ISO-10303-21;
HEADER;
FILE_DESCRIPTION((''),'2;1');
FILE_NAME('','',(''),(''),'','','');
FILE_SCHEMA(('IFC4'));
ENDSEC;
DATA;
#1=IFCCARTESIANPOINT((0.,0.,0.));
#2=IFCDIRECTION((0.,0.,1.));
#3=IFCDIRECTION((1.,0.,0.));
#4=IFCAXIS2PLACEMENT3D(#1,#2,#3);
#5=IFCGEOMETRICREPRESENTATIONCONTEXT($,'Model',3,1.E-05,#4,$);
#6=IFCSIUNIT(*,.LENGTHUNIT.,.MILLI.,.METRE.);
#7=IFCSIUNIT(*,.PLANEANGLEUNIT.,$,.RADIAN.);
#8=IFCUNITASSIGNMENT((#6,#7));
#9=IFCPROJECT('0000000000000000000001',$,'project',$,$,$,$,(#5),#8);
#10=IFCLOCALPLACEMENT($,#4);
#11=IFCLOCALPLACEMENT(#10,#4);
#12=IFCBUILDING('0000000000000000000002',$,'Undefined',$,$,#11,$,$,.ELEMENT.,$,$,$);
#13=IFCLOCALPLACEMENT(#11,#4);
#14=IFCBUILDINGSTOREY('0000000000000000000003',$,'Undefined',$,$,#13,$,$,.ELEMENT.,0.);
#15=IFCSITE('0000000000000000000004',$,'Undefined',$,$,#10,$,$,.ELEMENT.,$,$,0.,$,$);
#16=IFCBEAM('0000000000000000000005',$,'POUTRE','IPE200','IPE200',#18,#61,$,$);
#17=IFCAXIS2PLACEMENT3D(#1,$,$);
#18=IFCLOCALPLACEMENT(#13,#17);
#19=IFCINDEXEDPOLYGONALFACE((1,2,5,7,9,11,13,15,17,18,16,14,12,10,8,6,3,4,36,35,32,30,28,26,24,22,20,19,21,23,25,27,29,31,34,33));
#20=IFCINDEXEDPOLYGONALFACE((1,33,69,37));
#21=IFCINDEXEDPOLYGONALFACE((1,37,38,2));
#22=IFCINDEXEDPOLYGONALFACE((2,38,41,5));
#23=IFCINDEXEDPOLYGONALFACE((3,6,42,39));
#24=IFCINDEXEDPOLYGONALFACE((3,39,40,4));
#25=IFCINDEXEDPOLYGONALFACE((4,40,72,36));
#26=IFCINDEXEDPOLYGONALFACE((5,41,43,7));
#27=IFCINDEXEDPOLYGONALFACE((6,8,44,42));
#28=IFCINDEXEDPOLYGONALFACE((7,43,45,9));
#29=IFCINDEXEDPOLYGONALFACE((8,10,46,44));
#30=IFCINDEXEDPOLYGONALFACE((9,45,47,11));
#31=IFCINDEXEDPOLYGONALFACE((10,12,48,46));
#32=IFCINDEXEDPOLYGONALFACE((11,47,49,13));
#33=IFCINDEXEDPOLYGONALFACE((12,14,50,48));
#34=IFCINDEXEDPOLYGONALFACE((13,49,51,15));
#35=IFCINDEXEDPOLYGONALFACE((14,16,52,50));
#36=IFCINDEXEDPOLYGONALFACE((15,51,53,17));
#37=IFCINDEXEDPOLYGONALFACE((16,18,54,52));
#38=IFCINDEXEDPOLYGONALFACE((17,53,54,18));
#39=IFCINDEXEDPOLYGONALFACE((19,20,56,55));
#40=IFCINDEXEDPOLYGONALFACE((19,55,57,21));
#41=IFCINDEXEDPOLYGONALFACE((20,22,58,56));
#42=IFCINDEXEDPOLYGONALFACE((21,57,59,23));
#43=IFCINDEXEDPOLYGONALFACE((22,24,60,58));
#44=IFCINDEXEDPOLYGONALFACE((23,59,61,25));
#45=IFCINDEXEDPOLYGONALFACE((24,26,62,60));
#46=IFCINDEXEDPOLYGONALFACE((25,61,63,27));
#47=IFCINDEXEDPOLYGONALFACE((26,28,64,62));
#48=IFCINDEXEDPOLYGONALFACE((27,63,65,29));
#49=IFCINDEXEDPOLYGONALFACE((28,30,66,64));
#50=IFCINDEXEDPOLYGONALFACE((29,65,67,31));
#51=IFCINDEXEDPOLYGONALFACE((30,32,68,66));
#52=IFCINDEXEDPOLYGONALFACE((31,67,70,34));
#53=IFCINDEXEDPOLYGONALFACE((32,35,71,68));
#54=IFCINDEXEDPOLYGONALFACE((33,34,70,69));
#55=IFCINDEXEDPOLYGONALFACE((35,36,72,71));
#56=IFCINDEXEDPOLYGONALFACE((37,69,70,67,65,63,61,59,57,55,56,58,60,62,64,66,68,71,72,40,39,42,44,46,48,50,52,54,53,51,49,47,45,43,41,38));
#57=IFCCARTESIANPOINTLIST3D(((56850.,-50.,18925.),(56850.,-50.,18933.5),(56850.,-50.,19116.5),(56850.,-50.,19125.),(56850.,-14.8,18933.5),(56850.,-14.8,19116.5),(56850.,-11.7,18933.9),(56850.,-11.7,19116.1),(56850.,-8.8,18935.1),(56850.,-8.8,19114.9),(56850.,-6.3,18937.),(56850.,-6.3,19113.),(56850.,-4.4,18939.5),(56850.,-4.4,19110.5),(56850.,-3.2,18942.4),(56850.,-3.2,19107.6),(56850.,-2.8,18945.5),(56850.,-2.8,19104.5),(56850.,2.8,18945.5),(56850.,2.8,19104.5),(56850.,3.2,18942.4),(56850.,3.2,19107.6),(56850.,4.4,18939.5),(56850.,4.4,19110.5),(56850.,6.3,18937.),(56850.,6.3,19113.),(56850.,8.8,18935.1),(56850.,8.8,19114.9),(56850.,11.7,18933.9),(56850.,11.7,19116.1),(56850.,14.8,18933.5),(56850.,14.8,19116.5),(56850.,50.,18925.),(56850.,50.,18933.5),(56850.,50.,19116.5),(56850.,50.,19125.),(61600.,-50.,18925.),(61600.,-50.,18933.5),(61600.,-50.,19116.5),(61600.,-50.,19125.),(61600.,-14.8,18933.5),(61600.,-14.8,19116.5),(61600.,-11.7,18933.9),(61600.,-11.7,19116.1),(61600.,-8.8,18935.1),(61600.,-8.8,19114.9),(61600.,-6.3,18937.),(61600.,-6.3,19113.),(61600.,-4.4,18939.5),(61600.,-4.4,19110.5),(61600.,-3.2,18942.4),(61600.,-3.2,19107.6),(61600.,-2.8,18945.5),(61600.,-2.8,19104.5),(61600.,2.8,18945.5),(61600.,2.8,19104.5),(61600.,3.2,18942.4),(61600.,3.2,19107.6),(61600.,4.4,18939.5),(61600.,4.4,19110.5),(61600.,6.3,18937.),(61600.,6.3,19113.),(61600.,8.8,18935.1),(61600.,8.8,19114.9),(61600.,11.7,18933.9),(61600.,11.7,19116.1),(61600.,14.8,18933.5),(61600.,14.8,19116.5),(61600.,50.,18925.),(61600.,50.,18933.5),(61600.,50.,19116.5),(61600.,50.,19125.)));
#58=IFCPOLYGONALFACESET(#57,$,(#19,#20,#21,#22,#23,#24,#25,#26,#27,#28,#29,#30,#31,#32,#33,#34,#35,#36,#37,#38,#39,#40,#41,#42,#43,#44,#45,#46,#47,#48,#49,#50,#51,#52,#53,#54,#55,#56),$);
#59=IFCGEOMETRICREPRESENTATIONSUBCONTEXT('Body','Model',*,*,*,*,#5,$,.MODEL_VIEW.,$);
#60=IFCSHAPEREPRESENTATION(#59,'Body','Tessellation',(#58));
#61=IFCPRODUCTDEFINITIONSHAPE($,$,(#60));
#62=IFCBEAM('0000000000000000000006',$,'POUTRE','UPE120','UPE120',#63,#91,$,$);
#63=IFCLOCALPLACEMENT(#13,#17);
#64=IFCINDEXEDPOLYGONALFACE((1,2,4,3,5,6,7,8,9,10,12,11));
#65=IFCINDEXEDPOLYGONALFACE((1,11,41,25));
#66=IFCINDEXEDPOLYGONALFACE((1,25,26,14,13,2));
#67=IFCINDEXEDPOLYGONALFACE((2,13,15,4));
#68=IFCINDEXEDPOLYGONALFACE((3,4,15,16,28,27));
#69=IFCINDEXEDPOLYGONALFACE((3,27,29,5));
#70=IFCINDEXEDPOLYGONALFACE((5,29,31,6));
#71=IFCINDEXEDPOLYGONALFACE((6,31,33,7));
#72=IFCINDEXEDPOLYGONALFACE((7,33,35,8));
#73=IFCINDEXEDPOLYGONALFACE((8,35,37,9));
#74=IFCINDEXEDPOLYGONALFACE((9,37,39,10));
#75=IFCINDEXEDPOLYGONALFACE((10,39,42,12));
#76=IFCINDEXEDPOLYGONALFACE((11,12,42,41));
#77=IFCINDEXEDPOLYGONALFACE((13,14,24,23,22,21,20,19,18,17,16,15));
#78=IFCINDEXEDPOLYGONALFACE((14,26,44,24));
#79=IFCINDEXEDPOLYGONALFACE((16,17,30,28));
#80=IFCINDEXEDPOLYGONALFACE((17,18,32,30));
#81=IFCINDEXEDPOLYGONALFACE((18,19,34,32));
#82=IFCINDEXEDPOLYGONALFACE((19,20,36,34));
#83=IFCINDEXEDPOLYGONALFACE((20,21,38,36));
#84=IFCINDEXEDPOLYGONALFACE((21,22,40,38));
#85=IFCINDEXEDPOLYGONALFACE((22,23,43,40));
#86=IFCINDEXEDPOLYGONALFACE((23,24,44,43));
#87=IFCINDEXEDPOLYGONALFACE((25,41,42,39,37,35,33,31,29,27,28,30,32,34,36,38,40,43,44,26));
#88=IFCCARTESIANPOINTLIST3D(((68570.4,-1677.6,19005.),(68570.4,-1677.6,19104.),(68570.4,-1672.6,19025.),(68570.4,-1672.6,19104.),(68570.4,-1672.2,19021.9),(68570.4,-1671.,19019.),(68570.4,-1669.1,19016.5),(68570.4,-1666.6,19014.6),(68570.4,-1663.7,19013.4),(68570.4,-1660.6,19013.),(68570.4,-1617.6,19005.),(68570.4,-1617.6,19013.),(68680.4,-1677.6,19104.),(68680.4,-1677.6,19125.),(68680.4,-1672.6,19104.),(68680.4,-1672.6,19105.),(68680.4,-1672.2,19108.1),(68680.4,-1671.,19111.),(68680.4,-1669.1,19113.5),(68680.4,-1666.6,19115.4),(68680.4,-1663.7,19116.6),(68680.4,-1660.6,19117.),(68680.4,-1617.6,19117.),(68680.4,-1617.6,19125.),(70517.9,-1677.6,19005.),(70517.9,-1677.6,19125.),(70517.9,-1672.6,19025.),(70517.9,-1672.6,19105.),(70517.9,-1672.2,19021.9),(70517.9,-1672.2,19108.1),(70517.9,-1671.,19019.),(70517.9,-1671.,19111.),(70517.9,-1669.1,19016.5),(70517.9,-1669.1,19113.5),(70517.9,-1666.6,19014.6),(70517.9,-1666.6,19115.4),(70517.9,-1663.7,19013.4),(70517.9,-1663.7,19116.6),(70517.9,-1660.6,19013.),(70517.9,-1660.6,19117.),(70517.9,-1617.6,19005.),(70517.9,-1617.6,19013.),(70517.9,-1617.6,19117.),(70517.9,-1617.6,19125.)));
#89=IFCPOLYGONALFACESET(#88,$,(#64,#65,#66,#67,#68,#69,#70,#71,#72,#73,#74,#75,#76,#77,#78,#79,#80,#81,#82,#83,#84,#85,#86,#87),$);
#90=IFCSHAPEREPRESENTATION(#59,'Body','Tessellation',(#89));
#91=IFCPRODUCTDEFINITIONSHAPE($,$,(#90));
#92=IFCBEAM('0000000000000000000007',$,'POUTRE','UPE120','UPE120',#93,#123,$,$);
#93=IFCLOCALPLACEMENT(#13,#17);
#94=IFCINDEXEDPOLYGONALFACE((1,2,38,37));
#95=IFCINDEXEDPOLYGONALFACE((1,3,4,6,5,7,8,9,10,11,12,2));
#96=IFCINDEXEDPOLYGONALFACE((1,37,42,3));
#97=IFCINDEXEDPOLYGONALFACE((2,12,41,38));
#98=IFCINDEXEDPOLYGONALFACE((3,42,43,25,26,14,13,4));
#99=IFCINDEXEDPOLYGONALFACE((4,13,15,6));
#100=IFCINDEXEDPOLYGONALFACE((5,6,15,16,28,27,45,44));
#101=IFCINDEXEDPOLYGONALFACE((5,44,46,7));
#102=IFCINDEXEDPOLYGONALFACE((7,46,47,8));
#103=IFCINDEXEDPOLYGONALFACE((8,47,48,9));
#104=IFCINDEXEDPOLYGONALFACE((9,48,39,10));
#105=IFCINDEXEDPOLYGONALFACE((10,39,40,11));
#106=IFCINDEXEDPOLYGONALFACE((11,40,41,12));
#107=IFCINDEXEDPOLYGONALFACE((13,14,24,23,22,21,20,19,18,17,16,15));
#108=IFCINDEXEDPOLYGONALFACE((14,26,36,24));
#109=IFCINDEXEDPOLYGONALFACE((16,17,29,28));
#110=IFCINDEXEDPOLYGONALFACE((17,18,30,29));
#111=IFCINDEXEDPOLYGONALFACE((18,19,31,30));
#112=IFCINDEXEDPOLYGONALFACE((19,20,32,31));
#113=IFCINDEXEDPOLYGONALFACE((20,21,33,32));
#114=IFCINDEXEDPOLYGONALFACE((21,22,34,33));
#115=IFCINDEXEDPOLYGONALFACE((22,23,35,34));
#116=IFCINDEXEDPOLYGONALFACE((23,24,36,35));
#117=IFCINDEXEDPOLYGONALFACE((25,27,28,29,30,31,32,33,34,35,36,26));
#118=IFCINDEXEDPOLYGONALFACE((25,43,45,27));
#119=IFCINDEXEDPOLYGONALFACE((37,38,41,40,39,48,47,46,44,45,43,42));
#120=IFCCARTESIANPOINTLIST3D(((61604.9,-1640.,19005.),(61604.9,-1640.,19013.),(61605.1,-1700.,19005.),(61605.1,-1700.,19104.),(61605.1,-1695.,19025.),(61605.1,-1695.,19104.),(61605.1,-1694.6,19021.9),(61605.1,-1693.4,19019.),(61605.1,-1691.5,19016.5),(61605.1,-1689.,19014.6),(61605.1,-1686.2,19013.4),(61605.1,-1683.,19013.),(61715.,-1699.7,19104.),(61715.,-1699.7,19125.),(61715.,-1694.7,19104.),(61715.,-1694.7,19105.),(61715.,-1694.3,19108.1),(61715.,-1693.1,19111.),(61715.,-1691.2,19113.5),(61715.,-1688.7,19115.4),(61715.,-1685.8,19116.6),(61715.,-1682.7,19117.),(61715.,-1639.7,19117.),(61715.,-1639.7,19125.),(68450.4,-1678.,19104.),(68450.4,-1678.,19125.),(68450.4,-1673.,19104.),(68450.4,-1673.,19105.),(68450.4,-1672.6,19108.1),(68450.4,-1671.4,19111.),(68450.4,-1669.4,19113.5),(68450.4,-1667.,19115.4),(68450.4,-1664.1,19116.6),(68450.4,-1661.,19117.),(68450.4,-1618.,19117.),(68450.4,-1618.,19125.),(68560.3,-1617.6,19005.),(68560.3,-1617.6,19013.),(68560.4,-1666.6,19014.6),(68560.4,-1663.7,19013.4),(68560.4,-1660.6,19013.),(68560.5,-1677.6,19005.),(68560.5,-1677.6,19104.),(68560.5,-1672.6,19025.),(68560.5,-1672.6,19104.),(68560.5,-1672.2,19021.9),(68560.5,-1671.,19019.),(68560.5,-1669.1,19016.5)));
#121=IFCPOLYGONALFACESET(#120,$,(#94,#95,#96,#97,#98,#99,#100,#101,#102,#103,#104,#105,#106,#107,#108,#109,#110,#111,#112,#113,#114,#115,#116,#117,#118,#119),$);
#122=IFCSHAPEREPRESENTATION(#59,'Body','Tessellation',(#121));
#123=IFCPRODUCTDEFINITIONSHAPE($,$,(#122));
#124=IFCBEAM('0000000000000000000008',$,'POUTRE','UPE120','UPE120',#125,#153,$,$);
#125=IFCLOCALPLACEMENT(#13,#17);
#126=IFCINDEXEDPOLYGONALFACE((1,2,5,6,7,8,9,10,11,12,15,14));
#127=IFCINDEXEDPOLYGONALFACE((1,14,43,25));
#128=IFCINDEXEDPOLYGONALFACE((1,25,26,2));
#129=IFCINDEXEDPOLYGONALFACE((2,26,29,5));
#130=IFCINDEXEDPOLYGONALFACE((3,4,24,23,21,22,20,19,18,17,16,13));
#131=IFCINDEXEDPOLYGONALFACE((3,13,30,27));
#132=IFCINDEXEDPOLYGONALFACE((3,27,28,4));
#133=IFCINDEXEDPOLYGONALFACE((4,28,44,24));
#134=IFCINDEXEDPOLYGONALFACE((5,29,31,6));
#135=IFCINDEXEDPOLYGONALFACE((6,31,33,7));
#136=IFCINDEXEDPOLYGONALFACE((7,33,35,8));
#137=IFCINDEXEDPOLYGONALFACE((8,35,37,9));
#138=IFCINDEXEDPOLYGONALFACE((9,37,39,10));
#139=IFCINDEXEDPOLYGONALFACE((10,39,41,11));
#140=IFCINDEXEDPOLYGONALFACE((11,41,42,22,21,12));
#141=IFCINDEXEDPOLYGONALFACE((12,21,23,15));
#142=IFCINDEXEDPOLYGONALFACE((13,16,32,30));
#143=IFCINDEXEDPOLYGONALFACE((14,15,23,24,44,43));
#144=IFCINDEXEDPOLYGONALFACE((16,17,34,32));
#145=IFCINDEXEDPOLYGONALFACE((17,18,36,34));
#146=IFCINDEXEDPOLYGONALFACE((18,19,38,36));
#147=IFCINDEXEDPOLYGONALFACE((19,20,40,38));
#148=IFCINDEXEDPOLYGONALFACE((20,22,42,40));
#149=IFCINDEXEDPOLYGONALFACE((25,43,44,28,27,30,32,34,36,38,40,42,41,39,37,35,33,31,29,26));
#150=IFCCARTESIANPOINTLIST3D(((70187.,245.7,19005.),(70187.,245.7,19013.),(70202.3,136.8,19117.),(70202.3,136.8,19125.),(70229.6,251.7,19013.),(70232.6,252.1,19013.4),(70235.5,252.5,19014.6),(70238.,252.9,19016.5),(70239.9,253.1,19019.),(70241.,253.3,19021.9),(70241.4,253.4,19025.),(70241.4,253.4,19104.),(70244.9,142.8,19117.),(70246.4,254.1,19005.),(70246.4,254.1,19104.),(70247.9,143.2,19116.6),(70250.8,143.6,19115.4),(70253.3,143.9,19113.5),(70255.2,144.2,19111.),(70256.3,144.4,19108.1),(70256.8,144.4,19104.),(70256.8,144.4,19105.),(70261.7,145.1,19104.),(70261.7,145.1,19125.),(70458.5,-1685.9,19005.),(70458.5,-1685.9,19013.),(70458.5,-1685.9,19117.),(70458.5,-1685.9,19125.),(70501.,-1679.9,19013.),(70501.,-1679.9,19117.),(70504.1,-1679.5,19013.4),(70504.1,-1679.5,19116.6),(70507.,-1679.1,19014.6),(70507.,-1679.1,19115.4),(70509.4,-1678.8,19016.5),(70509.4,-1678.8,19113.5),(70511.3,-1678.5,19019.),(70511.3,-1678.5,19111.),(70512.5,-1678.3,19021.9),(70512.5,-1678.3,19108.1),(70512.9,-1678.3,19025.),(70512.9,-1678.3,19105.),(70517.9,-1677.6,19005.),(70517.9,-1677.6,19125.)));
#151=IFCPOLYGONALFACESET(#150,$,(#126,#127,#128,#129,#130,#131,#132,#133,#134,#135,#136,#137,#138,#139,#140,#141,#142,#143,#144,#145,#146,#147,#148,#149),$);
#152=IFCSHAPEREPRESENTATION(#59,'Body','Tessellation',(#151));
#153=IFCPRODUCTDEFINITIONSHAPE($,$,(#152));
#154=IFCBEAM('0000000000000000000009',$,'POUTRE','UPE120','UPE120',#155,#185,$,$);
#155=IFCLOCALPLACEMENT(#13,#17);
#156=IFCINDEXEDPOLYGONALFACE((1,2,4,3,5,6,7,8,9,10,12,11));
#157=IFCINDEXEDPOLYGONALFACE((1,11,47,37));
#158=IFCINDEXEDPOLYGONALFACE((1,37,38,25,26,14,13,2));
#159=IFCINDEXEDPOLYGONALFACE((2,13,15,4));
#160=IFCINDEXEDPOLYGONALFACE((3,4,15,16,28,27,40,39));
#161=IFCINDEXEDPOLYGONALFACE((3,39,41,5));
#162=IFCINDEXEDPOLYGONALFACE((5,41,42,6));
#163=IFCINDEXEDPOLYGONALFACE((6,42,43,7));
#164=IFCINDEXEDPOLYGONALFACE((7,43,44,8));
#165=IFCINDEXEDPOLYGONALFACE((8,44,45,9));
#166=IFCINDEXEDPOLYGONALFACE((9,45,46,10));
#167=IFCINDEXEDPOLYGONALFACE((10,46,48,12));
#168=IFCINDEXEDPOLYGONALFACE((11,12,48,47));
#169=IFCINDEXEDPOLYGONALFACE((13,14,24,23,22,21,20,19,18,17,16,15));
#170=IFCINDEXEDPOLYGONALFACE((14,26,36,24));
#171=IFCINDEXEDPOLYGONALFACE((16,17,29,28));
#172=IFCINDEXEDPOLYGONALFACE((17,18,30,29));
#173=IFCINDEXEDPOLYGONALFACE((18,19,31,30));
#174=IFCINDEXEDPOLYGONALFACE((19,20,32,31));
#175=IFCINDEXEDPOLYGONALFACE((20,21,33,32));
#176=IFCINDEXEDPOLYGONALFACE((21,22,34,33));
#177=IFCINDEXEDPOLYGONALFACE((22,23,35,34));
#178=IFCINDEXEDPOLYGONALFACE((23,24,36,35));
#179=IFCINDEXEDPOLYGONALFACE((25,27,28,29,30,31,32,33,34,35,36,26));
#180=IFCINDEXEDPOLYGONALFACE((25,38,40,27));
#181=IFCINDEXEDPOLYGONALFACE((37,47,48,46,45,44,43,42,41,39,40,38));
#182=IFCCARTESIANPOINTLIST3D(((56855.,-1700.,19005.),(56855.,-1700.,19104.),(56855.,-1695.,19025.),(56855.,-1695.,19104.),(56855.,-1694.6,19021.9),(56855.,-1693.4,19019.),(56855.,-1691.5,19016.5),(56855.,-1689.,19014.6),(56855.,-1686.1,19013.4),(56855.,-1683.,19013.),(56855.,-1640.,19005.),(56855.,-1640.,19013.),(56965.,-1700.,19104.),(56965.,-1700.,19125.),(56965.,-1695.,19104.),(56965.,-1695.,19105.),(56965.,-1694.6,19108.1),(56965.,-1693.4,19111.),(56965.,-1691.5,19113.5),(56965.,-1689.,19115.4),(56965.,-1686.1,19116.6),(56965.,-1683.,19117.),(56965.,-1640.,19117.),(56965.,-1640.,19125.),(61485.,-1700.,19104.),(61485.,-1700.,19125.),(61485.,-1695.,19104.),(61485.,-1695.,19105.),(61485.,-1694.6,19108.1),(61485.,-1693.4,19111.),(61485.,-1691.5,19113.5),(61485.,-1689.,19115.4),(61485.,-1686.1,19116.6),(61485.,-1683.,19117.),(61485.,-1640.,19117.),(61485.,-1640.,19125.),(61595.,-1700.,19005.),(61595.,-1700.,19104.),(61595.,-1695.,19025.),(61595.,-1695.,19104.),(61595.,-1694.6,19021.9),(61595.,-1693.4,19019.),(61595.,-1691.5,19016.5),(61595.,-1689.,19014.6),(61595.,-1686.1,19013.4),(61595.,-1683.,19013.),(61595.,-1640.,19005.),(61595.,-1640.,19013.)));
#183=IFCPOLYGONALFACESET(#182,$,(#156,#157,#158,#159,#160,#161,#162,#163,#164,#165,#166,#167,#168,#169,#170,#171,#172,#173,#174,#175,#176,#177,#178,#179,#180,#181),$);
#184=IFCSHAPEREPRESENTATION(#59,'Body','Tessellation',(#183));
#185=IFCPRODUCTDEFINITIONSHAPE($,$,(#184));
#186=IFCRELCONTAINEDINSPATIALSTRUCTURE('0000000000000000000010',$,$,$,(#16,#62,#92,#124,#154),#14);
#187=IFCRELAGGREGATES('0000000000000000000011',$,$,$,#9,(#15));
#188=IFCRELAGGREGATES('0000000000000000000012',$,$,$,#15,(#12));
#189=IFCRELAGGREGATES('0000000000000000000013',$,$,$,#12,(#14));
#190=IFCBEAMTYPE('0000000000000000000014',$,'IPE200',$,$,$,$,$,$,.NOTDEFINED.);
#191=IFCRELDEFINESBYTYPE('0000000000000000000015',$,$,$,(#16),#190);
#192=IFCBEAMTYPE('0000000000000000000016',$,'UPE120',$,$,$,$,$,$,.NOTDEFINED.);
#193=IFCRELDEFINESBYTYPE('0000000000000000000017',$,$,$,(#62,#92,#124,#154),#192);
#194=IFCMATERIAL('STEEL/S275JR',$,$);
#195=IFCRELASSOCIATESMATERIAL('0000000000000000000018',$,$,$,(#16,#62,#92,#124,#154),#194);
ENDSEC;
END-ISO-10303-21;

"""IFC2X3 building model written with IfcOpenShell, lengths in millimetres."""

from ifc_helpers import new_model, si_unit, frame, origin_with_axes, origin_2d_with_axis, place, context, subcontext, project, spatial, rectangle, i_section, u_section, extrude, boolean, material, type_object, element, save


model = new_model("IFC2X3")

# Units and contexts
model_context = context("Model", 3, precision=1e-05, world=origin_with_axes())
body_context = subcontext(model_context, "Body", "Model", "MODEL_VIEW")
ifc_project = project(units=[si_unit("LENGTHUNIT", "METRE", prefix="MILLI"), si_unit("PLANEANGLEUNIT", "RADIAN")], contexts=[model_context])

# Site, building, storey
site_placement = place(None, origin_with_axes())
site = spatial("IfcSite", under=ifc_project, at=site_placement, Name="Undefined", CompositionType="ELEMENT", RefElevation=0.0)
building_placement = place(site_placement, origin_with_axes())
building = spatial("IfcBuilding", under=site, at=building_placement, Name="Undefined", CompositionType="ELEMENT")
storey_placement = place(building_placement, origin_with_axes())
storey = spatial("IfcBuildingStorey", under=building, at=storey_placement, Name="Undefined", CompositionType="ELEMENT", Elevation=0.0)

# Shared definitions
ifc_material_1 = material(Name="STEEL/S275JR")

# Beams
beam_type_1 = type_object("IfcBeamType", Name="IPE200", PredefinedType="NOTDEFINED")
for number, where, z_axis, x_axis, name in (
    (1, (56850.0, 0.0, 19025.0), (-0.000006, 0.0, 1.0), (1.0, 0.0, 0.000006), "POUTRE"),
):
    element("IfcBeam", number, at=place(storey_placement, frame(where, z_axis=z_axis, x_axis=x_axis)), inside=storey, type_object=beam_type_1, material=ifc_material_1, Name=name, Description="IPE200", ObjectType="IPE200", context=body_context, shape_type="SweptSolid", body=[
        extrude(i_section(OverallWidth=100.0, OverallDepth=200.0, WebThickness=5.6, FlangeThickness=8.5, FilletRadius=12.0, at=origin_2d_with_axis()), frame((4750.0, 0.0, 0.0), z_axis=(-1.0, 0.0, 0.0), x_axis=(0.0, -1.0, 0.0)), (0.0, 0.0, 1.0), 4750.0),
    ])
beam_type_2 = type_object("IfcBeamType", Name="UPE120", PredefinedType="NOTDEFINED")
beam_1_placement = place(storey_placement, frame((68571.9, -1647.6, 19065.0), z_axis=(0.0, 0.0, -1.0), x_axis=(1.0, 0.0, 0.0)))
element("IfcBeam", 2, at=beam_1_placement, inside=storey, type_object=beam_type_2, material=ifc_material_1, Name="POUTRE", Description="UPE120", ObjectType="UPE120", context=body_context, shape_type="CSG", body=[
    boolean("DIFFERENCE", extrude(u_section(Depth=120.0, FlangeWidth=60.0, WebThickness=5.0, FlangeThickness=8.0, FilletRadius=12.0, at=origin_2d_with_axis()), frame((1946.0, 0.0, 0.0), z_axis=(-1.0, 0.0, 0.0), x_axis=(0.0, -1.0, 0.0)), (0.0, 0.0, 1.0), 1947.5), extrude(rectangle(XDim=22.0, YDim=112.0, at=origin_2d_with_axis()), frame((52.5, 31.0, -50.0), z_axis=(0.0, -1.0, 0.0), x_axis=(0.0, 0.0, 1.0)), (0.0, 0.0, 1.0), 62.0)),
])
beam_2_placement = place(storey_placement, frame((61619.3, -1670.0, 19065.0), z_axis=(0.0, 0.0, -1.0), x_axis=(0.999995, 0.003226, 0.0)))
element("IfcBeam", 3, at=beam_2_placement, inside=storey, type_object=beam_type_2, material=ifc_material_1, Name="POUTRE", Description="UPE120", ObjectType="UPE120", context=body_context, shape_type="CSG", body=[
    boolean("DIFFERENCE", boolean("DIFFERENCE", extrude(u_section(Depth=120.0, FlangeWidth=60.0, WebThickness=5.0, FlangeThickness=8.0, FilletRadius=12.0, at=origin_2d_with_axis()), frame((6941.2, 0.0, 0.0), z_axis=(-1.0, 0.0, 0.0), x_axis=(0.0, -1.0, 0.0)), (0.0, 0.0, 1.0), 6955.4), extrude(rectangle(XDim=22.0, YDim=112.0, at=origin_2d_with_axis()), frame((6887.3, -31.2, -50.0), z_axis=(-0.003226, 0.999995, 0.0), x_axis=(0.0, 0.0, 1.0)), (0.0, 0.0, 1.0), 84.4)), extrude(rectangle(XDim=22.0, YDim=112.0, at=origin_2d_with_axis()), frame((39.6, 31.2, -50.0), z_axis=(0.003226, -0.999995, 0.0), x_axis=(0.0, 0.0, 1.0)), (0.0, 0.0, 1.0), 84.4)),
])
beam_3_placement = place(storey_placement, frame((70488.2, -1681.8, 19065.0), z_axis=(0.0, 0.0, -1.0), x_axis=(-0.139177, 0.990267, 0.0)))
element("IfcBeam", 4, at=beam_3_placement, inside=storey, type_object=beam_type_2, material=ifc_material_1, Name="POUTRE", Description="UPE120", ObjectType="UPE120", context=body_context, shape_type="CSG", body=[
    boolean("DIFFERENCE", extrude(u_section(Depth=120.0, FlangeWidth=60.0, WebThickness=5.0, FlangeThickness=8.0, FilletRadius=12.0, at=origin_2d_with_axis()), frame((1950.6, 0.0, 0.0), z_axis=(-1.0, 0.0, 0.0), x_axis=(0.0, -1.0, 0.0)), (0.0, 0.0, 1.0), 1950.6), extrude(rectangle(XDim=22.0, YDim=112.0, at=origin_2d_with_axis()), frame((1896.6, -31.0, -50.0), z_axis=(0.0, 1.0, 0.0), x_axis=(0.0, 0.0, 1.0)), (0.0, 0.0, 1.0), 62.0)),
])
beam_4_placement = place(storey_placement, frame((56859.7, -1670.0, 19065.0), z_axis=(0.0, 0.0, -1.0), x_axis=(1.0, 0.0, 0.0)))
element("IfcBeam", 5, at=beam_4_placement, inside=storey, type_object=beam_type_2, material=ifc_material_1, Name="POUTRE", Description="UPE120", ObjectType="UPE120", context=body_context, shape_type="CSG", body=[
    boolean("DIFFERENCE", boolean("DIFFERENCE", extrude(u_section(Depth=120.0, FlangeWidth=60.0, WebThickness=5.0, FlangeThickness=8.0, FilletRadius=12.0, at=origin_2d_with_axis()), frame((4735.3, 0.0, 0.0), z_axis=(-1.0, 0.0, 0.0), x_axis=(0.0, -1.0, 0.0)), (0.0, 0.0, 1.0), 4740.0), extrude(rectangle(XDim=22.0, YDim=112.0, at=origin_2d_with_axis()), frame((49.3, 31.0, -50.0), z_axis=(0.0, -1.0, 0.0), x_axis=(0.0, 0.0, 1.0)), (0.0, 0.0, 1.0), 62.0)), extrude(rectangle(XDim=22.0, YDim=112.0, at=origin_2d_with_axis()), frame((4681.3, -31.0, -50.0), z_axis=(0.0, 1.0, 0.0), x_axis=(0.0, 0.0, 1.0)), (0.0, 0.0, 1.0), 62.0)),
])

save(model, "model.ifc")
